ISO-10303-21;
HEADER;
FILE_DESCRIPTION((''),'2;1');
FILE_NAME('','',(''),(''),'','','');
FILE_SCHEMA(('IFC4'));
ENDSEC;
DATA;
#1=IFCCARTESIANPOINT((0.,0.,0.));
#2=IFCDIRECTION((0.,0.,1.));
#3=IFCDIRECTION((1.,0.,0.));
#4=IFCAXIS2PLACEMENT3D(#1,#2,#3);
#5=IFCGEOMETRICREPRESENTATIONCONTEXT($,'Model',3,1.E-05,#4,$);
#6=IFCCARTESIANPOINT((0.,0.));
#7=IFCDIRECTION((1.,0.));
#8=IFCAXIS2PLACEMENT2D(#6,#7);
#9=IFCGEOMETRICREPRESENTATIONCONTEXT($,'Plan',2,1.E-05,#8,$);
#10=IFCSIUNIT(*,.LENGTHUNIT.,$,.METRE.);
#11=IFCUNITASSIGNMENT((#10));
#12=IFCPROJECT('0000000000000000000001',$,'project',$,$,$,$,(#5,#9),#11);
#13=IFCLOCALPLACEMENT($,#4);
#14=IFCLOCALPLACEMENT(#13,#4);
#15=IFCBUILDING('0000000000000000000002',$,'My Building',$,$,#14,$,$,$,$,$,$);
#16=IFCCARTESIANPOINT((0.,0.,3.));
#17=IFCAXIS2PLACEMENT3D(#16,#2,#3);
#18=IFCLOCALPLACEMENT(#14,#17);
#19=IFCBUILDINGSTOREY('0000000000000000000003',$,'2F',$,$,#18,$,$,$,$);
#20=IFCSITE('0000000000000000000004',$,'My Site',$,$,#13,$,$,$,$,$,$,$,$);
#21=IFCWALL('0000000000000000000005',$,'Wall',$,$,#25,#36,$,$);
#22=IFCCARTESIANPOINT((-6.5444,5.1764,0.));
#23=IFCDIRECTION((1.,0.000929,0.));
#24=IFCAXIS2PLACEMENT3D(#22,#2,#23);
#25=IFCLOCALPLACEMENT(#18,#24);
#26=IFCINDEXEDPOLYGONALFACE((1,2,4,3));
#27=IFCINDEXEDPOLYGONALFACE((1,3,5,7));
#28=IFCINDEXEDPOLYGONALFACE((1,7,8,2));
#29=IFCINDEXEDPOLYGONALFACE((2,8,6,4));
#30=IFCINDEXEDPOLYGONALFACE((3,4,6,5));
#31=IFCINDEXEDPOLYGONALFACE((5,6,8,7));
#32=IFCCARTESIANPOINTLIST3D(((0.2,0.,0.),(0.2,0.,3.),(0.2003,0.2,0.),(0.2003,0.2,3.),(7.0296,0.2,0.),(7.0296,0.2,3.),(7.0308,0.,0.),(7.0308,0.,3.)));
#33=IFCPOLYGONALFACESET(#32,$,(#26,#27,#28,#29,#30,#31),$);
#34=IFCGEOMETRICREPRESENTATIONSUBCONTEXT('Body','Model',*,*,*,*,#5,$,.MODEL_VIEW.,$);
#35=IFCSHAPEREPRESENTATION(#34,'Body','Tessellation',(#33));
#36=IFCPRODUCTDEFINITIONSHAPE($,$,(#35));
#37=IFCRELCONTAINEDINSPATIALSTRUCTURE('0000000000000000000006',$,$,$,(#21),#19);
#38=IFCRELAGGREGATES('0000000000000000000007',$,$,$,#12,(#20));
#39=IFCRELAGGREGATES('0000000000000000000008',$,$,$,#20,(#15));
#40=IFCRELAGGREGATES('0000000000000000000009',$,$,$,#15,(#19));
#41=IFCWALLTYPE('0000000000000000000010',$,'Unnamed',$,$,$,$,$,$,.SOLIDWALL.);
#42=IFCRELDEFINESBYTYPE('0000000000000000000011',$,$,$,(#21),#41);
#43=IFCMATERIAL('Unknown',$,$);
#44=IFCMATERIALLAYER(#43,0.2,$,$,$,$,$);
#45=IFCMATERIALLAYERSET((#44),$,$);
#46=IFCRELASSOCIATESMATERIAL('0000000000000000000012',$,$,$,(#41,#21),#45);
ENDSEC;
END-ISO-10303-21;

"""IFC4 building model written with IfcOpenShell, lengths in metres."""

from ifc_helpers import new_model, si_unit, frame, origin_with_axes, origin_2d_with_axis, place, context, subcontext, project, spatial, line, indexed_curve, outline, extrude, material, layer, layer_set, layer_usage, type_object, element, save


model = new_model("IFC4")

# Units and contexts
model_context = context("Model", 3, precision=1e-05, world=origin_with_axes())
plan_context = context("Plan", 2, precision=1e-05, world=origin_2d_with_axis())
body_context_1 = subcontext(model_context, "Body", "Model", "MODEL_VIEW")
ifc_project = project(units=[si_unit("LENGTHUNIT", "METRE")], contexts=[model_context, plan_context])

# Site, building, storey
site_placement = place(None, origin_with_axes())
site = spatial("IfcSite", under=ifc_project, at=site_placement, Name="My Site")
building_placement = place(site_placement, origin_with_axes())
building = spatial("IfcBuilding", under=site, at=building_placement, Name="My Building")
storey_placement = place(building_placement, frame((0.0, 0.0, 3.0), z_axis=(0.0, 0.0, 1.0), x_axis=(1.0, 0.0, 0.0)))
storey = spatial("IfcBuildingStorey", under=building, at=storey_placement, Name="2F")

# Shared definitions
ifc_material = material(Name="Unknown")

# Shared definitions
ifc_layer_1 = layer(ifc_material, 0.2)
ifc_layer_set_1 = layer_set([ifc_layer_1])
wall_type = type_object("IfcWallType", Name="Unnamed", PredefinedType="SOLIDWALL", material=ifc_layer_set_1)

# Wall
ifc_layer_usage_1 = layer_usage(ifc_layer_set_1, "AXIS2", "POSITIVE", 0.0)
wall_1_placement = place(storey_placement, frame((-6.5444, 5.1764, 0.0), z_axis=(0.0, 0.0, 1.0), x_axis=(1.0, 0.000929, 0.0)))
element("IfcWall", 1, at=wall_1_placement, inside=storey, type_object=wall_type, material=ifc_layer_usage_1, Name="Wall", context=body_context_1, shape_type="SweptSolid", body=[
    extrude(outline(indexed_curve([(0.2, 0.0), (0.2003, 0.2), (7.0296, 0.2), (7.0308, 0.0)], segments=[line(1, 2, 3, 4, 1)])), origin_with_axes(), (0.0, 0.0, 1.0), 3.0),
])

save(model, "model.ifc")
